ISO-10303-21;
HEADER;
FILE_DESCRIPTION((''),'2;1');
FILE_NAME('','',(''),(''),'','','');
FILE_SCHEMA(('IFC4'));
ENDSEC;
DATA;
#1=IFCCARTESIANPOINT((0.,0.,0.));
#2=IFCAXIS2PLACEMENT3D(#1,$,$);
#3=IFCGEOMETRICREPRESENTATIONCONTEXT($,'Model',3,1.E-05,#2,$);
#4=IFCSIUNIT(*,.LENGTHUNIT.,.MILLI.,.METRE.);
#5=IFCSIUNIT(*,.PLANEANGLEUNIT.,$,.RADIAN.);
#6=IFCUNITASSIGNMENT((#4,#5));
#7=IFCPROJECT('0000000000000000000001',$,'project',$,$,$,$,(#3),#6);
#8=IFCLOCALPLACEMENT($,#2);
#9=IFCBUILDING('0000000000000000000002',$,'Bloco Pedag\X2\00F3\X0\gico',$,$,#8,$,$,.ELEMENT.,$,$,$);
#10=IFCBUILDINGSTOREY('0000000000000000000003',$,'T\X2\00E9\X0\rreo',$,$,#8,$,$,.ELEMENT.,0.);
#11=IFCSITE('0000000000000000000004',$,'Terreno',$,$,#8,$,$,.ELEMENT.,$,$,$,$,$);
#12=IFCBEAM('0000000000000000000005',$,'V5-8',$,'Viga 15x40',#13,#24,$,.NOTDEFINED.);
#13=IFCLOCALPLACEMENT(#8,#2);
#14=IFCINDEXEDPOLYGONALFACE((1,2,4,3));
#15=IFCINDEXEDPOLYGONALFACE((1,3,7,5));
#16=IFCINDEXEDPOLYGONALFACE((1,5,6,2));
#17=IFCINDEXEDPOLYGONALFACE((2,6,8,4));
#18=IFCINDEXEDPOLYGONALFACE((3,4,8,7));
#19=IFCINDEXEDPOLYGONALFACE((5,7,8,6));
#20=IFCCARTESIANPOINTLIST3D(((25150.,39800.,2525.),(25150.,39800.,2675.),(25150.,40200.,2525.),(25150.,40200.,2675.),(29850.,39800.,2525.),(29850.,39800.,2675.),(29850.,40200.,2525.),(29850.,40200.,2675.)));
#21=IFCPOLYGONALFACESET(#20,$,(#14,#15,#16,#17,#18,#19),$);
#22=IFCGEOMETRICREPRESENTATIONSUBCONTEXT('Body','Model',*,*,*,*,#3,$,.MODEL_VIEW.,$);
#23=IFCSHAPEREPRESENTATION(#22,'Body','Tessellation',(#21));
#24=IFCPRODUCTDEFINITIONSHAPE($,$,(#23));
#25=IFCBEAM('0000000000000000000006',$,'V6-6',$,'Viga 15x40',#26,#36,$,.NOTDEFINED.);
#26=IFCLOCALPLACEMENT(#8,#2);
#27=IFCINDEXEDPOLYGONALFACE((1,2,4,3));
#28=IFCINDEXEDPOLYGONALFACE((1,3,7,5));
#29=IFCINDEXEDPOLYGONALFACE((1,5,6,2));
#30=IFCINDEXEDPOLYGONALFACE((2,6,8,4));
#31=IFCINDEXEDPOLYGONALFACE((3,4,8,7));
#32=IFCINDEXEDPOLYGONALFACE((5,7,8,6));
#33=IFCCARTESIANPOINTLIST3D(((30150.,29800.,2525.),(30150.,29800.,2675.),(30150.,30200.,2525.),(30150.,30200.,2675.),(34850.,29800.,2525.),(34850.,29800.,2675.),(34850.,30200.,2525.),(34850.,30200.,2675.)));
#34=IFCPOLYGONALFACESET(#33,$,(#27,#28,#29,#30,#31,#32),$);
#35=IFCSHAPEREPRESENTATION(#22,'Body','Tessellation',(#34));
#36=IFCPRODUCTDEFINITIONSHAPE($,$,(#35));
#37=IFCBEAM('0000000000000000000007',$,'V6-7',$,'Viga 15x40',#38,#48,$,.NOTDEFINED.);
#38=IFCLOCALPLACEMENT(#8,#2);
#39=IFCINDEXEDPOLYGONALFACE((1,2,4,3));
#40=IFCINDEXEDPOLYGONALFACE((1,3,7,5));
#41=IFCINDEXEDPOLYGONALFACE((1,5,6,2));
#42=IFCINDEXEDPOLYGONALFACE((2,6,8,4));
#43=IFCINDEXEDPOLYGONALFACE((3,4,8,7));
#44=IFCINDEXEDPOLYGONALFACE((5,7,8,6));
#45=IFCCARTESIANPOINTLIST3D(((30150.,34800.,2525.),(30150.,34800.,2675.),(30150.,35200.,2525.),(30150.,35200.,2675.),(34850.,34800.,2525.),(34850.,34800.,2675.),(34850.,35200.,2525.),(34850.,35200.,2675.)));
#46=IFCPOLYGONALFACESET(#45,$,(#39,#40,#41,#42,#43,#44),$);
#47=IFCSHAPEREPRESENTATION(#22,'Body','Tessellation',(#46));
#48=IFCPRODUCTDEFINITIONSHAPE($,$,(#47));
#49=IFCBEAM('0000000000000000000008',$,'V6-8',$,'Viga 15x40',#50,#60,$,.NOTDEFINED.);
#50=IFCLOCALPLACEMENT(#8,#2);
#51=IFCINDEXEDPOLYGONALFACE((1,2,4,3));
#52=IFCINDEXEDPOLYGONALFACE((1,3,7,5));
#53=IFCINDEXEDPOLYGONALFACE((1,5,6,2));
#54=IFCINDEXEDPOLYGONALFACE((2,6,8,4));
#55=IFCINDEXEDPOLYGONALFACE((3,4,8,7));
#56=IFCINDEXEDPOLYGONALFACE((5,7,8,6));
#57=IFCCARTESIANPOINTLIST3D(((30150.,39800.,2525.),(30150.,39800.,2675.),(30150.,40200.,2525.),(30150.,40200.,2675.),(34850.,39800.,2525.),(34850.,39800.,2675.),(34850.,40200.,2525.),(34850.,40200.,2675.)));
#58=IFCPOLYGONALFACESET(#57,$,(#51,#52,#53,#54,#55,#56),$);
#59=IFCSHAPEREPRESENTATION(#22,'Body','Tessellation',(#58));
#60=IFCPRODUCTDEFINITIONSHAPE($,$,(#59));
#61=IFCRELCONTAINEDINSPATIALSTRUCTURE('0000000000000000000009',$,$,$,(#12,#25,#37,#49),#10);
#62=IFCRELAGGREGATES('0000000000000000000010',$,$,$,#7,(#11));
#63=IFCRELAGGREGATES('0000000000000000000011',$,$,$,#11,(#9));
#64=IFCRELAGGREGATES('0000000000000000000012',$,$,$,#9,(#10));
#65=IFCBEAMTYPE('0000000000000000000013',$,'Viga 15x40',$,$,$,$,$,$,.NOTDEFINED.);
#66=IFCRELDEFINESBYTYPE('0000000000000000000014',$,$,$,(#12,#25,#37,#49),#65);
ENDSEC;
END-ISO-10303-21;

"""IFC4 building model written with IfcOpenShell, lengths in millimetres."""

from ifc_helpers import new_model, si_unit, frame, origin, origin_2d, place, context, subcontext, project, spatial, rectangle, extrude, type_object, element, save


model = new_model("IFC4")

# Units and contexts
model_context = context("Model", 3, precision=1e-05, world=origin())
body_context = subcontext(model_context, "Body", "Model", "MODEL_VIEW")
ifc_project = project(units=[si_unit("LENGTHUNIT", "METRE", prefix="MILLI"), si_unit("PLANEANGLEUNIT", "RADIAN")], contexts=[model_context])

# Site, building, storey
placement = place(None, origin())
site = spatial("IfcSite", under=ifc_project, at=placement, Name="Terreno", CompositionType="ELEMENT")
building = spatial("IfcBuilding", under=site, at=placement, Name="Bloco Pedagógico", CompositionType="ELEMENT")
storey = spatial("IfcBuildingStorey", under=building, at=placement, Name="Térreo", CompositionType="ELEMENT", Elevation=0.0)

# Beams
beam_type = type_object("IfcBeamType", Name="Viga 15x40", PredefinedType="NOTDEFINED")
for number, where, z_axis, x_axis, name in (
    (1, (25150.0, 40000.0, 2600.0), (1.0, 0.0, 0.0), (0.0, 1.0, 0.0), "V5-8"),
    (2, (30150.0, 30000.0, 2600.0), (1.0, 0.0, 0.0), (0.0, 1.0, 0.0), "V6-6"),
    (3, (30150.0, 35000.0, 2600.0), (1.0, 0.0, 0.0), (0.0, 1.0, 0.0), "V6-7"),
    (4, (30150.0, 40000.0, 2600.0), (1.0, 0.0, 0.0), (0.0, 1.0, 0.0), "V6-8"),
):
    element("IfcBeam", number, at=place(None, frame(where, z_axis=z_axis, x_axis=x_axis)), inside=storey, type_object=beam_type, Name=name, ObjectType="Viga 15x40", PredefinedType="NOTDEFINED", context=body_context, shape_type="SweptSolid", body=[
        extrude(rectangle(XDim=400.0, YDim=150.0, at=origin_2d()), None, (0.0, 0.0, 1.0), 4700.0),
    ])

save(model, "model.ifc")
